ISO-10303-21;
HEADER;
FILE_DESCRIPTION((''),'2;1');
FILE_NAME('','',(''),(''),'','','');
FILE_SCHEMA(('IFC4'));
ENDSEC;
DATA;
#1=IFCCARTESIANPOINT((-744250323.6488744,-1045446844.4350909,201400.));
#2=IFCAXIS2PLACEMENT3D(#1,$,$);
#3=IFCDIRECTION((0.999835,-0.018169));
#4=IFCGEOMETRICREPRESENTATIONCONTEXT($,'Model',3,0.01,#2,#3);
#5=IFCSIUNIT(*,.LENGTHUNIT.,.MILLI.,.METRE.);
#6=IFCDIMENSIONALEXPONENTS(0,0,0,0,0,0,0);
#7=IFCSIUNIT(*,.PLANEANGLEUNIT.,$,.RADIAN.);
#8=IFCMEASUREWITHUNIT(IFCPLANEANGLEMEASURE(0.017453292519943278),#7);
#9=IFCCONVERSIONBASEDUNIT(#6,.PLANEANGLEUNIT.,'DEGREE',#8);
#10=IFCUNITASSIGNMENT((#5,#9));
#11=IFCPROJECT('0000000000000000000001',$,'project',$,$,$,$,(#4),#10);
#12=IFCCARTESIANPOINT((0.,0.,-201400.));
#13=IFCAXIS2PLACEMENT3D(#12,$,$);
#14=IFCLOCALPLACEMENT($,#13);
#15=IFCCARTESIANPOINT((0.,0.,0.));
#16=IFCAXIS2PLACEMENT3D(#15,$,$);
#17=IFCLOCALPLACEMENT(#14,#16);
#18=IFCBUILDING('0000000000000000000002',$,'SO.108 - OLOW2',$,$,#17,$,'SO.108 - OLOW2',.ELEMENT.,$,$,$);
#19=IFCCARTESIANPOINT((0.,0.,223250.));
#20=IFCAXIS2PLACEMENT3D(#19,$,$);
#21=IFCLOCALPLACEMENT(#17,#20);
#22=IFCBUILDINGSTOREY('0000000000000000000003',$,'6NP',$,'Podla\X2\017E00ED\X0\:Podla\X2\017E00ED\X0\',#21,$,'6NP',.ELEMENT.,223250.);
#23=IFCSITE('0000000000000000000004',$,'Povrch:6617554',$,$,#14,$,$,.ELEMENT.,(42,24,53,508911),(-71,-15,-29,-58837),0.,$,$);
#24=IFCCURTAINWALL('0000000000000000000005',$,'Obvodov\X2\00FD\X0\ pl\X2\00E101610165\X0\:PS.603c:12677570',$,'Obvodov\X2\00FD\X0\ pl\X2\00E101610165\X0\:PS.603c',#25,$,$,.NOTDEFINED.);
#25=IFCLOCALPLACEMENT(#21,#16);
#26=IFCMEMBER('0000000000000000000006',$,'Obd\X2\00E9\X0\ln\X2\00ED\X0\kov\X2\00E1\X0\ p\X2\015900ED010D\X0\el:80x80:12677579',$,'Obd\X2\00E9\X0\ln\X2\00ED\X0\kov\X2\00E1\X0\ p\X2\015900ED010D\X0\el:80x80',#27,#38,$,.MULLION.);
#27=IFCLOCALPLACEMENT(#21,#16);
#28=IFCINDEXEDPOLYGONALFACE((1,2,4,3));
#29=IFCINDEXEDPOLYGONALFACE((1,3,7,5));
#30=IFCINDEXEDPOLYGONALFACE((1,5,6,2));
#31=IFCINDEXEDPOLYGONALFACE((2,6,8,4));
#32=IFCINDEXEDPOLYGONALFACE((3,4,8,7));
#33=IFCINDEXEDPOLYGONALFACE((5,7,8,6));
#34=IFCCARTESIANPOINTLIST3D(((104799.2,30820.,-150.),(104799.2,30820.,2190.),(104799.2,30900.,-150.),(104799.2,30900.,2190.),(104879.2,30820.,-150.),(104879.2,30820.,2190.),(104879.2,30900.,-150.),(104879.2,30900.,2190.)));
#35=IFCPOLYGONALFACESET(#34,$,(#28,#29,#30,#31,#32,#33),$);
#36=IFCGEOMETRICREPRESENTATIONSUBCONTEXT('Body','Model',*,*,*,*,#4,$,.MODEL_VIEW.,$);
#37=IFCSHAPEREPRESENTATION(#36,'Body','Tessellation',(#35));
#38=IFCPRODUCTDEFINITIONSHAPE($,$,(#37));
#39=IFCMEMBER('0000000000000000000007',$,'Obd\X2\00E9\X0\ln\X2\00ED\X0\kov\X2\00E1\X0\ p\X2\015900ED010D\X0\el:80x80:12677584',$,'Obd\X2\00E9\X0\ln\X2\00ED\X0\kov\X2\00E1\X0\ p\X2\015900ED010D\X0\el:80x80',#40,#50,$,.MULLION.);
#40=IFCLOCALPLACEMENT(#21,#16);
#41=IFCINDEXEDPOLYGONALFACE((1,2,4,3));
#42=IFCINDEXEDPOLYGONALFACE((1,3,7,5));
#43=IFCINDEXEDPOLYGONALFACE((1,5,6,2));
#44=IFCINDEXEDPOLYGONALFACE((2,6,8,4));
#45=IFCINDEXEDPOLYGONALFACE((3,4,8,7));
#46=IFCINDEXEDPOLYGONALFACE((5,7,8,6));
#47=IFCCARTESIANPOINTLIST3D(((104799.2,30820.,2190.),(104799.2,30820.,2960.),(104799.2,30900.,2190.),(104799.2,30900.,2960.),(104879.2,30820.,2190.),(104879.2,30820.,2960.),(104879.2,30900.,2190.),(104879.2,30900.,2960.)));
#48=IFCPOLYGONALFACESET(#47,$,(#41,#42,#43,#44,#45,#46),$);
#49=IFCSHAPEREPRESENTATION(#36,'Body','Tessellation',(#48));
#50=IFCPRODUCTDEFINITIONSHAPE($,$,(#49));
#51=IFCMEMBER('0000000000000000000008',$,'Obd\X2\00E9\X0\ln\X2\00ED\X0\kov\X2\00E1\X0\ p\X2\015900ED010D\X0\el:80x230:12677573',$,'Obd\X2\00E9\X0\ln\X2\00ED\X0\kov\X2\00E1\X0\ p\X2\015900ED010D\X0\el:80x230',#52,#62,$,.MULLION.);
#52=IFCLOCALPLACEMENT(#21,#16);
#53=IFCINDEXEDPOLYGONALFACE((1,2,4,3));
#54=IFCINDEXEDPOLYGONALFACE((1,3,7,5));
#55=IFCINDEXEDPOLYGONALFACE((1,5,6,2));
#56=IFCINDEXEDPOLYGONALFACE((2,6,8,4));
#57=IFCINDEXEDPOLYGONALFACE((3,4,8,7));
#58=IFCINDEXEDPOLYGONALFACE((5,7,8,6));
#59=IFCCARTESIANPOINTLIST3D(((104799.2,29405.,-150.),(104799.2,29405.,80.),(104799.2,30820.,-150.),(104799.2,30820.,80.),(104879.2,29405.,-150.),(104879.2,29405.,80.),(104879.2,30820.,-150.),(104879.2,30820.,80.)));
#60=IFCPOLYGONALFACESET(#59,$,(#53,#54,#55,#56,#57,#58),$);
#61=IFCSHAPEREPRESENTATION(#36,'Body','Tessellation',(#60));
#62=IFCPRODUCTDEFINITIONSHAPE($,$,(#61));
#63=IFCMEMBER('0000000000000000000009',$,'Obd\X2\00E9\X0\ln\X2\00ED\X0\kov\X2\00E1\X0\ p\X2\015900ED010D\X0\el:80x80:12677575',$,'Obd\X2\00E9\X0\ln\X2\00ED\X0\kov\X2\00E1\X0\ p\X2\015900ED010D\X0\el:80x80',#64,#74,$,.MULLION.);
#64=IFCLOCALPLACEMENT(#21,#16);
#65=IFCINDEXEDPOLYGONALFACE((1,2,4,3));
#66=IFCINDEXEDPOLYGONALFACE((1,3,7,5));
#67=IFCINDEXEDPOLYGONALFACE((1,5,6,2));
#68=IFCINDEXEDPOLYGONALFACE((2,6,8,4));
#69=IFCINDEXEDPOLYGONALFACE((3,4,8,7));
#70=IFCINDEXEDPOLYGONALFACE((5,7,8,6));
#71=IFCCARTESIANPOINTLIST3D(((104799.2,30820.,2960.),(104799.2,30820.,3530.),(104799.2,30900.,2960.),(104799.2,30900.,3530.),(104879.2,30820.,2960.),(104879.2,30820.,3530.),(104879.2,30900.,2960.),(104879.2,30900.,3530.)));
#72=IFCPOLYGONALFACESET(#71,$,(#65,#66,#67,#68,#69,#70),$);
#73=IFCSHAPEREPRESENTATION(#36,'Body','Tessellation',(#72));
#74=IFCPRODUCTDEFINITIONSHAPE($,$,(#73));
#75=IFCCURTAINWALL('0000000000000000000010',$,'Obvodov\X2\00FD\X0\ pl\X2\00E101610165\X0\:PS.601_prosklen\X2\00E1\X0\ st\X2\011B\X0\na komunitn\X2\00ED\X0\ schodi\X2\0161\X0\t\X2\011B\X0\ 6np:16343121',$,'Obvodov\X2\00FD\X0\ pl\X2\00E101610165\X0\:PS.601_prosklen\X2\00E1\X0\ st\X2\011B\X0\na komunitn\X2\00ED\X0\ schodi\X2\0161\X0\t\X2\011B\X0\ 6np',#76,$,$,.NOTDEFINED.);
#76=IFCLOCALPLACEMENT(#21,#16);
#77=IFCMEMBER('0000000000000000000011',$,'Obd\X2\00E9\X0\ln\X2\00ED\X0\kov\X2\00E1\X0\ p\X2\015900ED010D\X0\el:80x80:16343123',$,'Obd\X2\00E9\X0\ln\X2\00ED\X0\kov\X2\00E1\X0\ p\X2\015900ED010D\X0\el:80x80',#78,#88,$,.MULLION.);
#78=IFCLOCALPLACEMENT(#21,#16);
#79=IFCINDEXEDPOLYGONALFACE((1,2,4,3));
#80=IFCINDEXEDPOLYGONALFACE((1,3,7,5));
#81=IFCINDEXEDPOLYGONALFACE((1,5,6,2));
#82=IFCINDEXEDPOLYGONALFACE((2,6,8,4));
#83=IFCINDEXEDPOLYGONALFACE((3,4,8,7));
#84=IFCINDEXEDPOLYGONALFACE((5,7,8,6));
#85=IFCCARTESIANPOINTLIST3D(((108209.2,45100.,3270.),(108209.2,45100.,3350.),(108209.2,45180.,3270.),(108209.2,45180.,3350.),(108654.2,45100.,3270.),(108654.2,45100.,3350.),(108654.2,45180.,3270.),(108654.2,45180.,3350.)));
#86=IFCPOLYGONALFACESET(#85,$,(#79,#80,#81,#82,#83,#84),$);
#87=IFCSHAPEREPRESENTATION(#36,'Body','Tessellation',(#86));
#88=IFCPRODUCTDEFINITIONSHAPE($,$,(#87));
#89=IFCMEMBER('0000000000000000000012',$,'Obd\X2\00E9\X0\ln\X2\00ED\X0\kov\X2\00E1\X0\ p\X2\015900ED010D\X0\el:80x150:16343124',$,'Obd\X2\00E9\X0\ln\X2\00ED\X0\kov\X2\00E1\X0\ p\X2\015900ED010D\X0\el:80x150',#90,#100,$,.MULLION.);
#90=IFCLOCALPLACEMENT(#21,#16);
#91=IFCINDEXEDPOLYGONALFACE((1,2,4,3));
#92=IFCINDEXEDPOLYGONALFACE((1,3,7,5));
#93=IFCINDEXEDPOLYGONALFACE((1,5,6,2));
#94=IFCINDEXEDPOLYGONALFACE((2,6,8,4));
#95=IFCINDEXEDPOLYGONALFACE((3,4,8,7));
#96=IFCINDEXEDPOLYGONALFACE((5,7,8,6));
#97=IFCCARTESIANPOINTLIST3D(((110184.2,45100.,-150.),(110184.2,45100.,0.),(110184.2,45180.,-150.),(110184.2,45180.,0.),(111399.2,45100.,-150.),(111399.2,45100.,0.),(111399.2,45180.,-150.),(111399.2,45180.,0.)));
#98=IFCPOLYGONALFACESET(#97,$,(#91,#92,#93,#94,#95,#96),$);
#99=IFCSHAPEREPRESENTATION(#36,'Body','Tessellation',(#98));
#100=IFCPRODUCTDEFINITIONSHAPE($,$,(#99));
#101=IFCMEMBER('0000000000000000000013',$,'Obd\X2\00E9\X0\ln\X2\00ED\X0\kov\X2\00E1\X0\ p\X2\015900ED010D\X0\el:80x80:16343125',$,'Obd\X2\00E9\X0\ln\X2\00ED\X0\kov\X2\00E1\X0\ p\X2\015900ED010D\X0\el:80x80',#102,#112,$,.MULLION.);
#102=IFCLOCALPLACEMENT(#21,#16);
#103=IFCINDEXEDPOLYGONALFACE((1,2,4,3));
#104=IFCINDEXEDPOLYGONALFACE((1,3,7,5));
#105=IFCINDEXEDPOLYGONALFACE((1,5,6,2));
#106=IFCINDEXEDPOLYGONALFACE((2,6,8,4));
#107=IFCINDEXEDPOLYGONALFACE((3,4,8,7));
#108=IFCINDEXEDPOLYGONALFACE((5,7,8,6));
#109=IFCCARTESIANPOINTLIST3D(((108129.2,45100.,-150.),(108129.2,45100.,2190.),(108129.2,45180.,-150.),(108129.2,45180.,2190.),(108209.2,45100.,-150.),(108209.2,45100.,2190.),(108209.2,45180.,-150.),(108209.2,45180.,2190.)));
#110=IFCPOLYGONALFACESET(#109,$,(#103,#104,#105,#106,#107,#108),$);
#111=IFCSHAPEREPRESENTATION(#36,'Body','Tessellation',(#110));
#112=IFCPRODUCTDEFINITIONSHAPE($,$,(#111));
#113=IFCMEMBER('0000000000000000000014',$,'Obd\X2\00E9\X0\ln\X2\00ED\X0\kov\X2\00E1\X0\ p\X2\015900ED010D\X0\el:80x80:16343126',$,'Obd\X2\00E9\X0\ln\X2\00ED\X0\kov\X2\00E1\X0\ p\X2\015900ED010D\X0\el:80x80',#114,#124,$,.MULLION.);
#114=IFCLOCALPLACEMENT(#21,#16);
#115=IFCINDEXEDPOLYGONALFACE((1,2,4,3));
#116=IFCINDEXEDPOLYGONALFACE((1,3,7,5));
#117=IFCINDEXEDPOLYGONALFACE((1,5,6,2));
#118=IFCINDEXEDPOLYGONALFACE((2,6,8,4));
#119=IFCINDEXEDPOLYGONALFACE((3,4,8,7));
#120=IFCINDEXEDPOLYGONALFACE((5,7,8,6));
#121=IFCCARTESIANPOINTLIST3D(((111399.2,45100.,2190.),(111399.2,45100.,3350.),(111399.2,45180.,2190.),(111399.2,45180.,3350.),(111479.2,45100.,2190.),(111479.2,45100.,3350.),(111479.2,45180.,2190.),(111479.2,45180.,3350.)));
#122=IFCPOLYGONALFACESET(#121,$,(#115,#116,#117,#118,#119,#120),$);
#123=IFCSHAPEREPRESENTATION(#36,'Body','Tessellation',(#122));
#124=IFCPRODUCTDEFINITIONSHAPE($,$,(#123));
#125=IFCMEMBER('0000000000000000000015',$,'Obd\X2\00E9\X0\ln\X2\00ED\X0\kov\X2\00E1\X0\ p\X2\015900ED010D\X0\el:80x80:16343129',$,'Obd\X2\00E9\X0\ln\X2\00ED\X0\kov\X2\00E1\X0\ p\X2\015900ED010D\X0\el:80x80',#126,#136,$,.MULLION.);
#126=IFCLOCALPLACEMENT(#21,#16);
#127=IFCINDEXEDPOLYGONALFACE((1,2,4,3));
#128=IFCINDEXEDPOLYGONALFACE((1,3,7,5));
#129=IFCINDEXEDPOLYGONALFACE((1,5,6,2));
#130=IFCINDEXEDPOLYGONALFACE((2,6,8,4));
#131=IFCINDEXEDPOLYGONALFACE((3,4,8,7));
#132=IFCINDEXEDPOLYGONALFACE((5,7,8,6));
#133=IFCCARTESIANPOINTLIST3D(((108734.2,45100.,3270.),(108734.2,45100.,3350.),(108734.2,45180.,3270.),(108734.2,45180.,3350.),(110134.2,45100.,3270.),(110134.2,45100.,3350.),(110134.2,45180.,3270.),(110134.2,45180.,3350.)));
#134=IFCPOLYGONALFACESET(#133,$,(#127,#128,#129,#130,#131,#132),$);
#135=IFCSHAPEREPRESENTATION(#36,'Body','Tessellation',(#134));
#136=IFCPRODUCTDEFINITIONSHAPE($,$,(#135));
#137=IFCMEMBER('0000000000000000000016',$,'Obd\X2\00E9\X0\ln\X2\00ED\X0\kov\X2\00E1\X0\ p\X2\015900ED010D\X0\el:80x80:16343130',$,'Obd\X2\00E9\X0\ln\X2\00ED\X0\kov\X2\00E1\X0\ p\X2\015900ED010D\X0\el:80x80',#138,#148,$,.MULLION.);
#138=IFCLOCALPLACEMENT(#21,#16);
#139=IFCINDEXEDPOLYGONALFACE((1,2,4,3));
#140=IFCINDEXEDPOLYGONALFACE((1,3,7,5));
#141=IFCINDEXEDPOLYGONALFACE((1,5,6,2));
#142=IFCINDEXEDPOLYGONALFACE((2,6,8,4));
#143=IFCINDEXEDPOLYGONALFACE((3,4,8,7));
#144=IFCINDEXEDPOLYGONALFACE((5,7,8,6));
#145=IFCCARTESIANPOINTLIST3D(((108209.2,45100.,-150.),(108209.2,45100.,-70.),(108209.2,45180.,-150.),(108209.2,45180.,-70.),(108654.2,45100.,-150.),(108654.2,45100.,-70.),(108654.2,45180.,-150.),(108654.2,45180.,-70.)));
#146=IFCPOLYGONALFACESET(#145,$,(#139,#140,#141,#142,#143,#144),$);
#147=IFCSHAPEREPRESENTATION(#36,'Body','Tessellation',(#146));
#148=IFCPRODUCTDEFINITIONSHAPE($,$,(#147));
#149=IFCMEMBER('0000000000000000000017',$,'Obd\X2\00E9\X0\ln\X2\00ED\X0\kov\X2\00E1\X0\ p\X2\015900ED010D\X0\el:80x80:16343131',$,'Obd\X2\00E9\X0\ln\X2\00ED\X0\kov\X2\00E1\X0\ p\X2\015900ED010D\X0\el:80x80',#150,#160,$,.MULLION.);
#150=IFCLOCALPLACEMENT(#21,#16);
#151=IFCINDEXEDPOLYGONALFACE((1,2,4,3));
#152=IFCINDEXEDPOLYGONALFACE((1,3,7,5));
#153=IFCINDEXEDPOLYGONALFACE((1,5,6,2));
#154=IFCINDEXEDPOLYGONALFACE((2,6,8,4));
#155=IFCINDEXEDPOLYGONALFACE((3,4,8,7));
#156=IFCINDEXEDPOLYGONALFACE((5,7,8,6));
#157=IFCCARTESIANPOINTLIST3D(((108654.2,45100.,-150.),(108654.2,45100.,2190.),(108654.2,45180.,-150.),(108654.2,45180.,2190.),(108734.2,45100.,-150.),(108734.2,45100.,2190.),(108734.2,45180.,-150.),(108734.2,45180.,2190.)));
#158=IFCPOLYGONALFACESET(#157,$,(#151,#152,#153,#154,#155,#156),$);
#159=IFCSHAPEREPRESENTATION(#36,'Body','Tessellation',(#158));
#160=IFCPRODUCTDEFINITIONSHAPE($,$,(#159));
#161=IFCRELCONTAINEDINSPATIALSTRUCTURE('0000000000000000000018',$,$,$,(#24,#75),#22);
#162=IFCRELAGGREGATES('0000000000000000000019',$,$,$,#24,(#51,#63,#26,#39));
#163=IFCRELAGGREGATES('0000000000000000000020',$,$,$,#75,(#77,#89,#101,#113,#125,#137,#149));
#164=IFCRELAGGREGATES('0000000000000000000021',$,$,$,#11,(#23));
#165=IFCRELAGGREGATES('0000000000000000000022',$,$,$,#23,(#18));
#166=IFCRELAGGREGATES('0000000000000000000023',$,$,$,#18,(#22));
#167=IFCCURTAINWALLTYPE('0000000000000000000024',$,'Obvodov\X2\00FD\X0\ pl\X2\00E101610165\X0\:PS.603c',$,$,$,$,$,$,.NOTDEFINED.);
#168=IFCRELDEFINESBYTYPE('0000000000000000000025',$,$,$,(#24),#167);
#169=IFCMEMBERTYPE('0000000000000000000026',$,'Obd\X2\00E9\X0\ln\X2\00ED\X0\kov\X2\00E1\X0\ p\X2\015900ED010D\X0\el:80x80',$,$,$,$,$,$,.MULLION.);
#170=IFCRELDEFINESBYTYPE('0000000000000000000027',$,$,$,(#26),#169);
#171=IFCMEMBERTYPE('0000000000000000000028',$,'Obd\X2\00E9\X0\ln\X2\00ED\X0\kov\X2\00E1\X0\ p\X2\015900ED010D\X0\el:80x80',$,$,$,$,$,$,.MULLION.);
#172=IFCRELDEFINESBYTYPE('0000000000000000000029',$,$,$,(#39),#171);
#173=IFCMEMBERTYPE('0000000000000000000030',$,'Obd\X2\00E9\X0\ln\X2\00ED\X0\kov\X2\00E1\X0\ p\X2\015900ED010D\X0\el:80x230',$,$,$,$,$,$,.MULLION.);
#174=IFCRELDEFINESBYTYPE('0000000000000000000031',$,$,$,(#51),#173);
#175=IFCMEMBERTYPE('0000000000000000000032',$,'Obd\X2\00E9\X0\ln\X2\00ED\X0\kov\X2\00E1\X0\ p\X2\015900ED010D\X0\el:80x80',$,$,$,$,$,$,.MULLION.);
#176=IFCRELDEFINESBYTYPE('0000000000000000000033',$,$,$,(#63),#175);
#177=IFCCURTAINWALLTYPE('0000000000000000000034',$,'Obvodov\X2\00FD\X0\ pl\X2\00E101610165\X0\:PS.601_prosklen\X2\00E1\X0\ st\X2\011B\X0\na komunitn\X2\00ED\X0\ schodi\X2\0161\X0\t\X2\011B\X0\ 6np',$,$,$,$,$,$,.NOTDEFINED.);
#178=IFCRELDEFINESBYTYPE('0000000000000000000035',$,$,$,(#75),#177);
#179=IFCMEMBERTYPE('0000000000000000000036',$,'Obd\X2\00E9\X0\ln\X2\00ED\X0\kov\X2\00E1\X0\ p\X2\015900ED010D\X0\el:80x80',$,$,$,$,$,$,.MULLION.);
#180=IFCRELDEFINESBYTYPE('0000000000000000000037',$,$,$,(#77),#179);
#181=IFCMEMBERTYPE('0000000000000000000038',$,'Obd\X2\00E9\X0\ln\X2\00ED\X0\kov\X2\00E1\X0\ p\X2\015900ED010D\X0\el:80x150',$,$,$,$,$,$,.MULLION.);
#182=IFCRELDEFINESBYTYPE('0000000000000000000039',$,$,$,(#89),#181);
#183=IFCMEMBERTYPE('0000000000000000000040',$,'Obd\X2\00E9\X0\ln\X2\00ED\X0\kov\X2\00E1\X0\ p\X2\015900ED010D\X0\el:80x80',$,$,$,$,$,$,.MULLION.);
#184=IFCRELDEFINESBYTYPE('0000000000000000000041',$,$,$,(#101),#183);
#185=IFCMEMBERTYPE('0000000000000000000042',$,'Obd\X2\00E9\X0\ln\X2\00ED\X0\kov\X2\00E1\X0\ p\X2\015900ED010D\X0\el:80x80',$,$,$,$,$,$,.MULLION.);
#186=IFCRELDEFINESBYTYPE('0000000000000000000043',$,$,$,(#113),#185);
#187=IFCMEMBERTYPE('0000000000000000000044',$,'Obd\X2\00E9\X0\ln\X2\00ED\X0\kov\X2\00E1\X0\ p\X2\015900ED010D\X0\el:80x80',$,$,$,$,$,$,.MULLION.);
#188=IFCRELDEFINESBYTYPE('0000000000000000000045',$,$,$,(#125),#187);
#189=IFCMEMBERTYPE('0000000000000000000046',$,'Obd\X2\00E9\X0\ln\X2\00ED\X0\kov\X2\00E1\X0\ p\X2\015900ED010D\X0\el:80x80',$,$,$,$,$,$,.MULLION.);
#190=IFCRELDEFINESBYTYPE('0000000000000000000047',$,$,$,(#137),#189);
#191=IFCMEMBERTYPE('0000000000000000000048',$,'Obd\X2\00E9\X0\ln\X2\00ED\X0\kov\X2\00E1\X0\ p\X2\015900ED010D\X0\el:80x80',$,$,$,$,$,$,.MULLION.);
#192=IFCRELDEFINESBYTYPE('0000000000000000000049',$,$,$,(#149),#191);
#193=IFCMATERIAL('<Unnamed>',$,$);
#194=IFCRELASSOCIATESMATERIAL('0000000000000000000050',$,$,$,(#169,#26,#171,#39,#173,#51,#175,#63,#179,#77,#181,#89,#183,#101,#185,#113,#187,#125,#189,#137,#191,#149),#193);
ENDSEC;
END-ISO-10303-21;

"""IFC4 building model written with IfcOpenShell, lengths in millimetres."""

from ifc_helpers import new_model, entity, si_unit, converted_unit, direction, frame, origin, place, context, subcontext, project, spatial, indexed_curve, outline, extrude, source, transform, mapped, material, type_object, type_shapes, element, aggregate, save


model = new_model("IFC4")

# Units and contexts
model_context = context("Model", 3, precision=0.01, world=frame((-744250323.6488744, -1045446844.4350909, 201400.0)), true_north=direction((0.999835, -0.018169)))
body_context = subcontext(model_context, "Body", "Model", "MODEL_VIEW")
ifc_project = project(units=[si_unit("LENGTHUNIT", "METRE", prefix="MILLI"), converted_unit("PLANEANGLEUNIT", "DEGREE", entity("IfcPlaneAngleMeasure", 0.017453292519943278), si_unit("PLANEANGLEUNIT", "RADIAN"), dimensions=[0, 0, 0, 0, 0, 0, 0])], contexts=[model_context])

# Site, building, storey
site_placement = place(None, frame((0.0, 0.0, -201400.0)))
site = spatial("IfcSite", under=ifc_project, at=site_placement, Name="Povrch:6617554", CompositionType="ELEMENT", RefLatitude=(42, 24, 53, 508911), RefLongitude=(-71, -15, -29, -58837), RefElevation=0.0)
building_placement = place(site_placement, origin())
building = spatial("IfcBuilding", under=site, at=building_placement, Name="SO.108 - OLOW2", LongName="SO.108 - OLOW2", CompositionType="ELEMENT")
storey_placement = place(building_placement, frame((0.0, 0.0, 223250.0)))
storey = spatial("IfcBuildingStorey", under=building, at=storey_placement, Name="6NP", ObjectType="Podlaží:Podlaží", LongName="6NP", CompositionType="ELEMENT", Elevation=223250.0)

# Curtain wall, members
curtain_wall_type_1 = type_object("IfcCurtainWallType", Name="Obvodový plášť:PS.603c", PredefinedType="NOTDEFINED")
curtain_wall_1_placement = place(storey_placement, frame((0.0, 0.0, -223250.0)))
curtain_wall_1 = element("IfcCurtainWall", 1, at=curtain_wall_1_placement, inside=storey, type_object=curtain_wall_type_1, Name="Obvodový plášť:PS.603c:12677570", ObjectType="Obvodový plášť:PS.603c", PredefinedType="NOTDEFINED")
ifc_material_1 = material(Name="<Unnamed>")
member_type_1 = type_object("IfcMemberType", Name="Obdélníková příčel:80x80", PredefinedType="MULLION", material=ifc_material_1)
shared_shape_1 = source(origin(), body_context, "Body", "SweptSolid", [
    extrude(outline(indexed_curve([(-40.0, -40.0), (40.0, -40.0), (40.0, 40.0), (-40.0, 40.0), (-40.0, -40.0)], self_intersect=False)), frame((-40.0, 0.0, -2340.0), z_axis=(0.0, 0.0, 1.0), x_axis=(-1.0, 0.0, 0.0)), (0.0, 0.0, 1.0), 2340.0),
])
type_shapes(member_type_1, [shared_shape_1])
member_1_placement = place(curtain_wall_1_placement, frame((104839.2, 30900.0, 225440.0), z_axis=(0.0, 0.0, 1.0), x_axis=(0.0, 1.0, 0.0)))
member_1 = element("IfcMember", 2, at=member_1_placement, type_object=member_type_1, material=ifc_material_1, Name="Obdélníková příčel:80x80:12677579", ObjectType="Obdélníková příčel:80x80", PredefinedType="MULLION", context=body_context, shape_type="MappedRepresentation", body=[
    mapped(shared_shape_1, transform((0.0, 0.0, 0.0), scale=1.0)),
])
member_type_2 = type_object("IfcMemberType", Name="Obdélníková příčel:80x80", PredefinedType="MULLION", material=ifc_material_1)
shared_shape_2 = source(origin(), body_context, "Body", "SweptSolid", [
    extrude(outline(indexed_curve([(-40.0, -40.0), (40.0, -40.0), (40.0, 40.0), (-40.0, 40.0), (-40.0, -40.0)], self_intersect=False)), frame((-40.0, 0.0, -770.0), z_axis=(0.0, 0.0, 1.0), x_axis=(-1.0, 0.0, 0.0)), (0.0, 0.0, 1.0), 770.0),
])
type_shapes(member_type_2, [shared_shape_2])
member_2_placement = place(curtain_wall_1_placement, frame((104839.2, 30900.0, 226210.0), z_axis=(0.0, 0.0, 1.0), x_axis=(0.0, 1.0, 0.0)))
member_2 = element("IfcMember", 3, at=member_2_placement, type_object=member_type_2, material=ifc_material_1, Name="Obdélníková příčel:80x80:12677584", ObjectType="Obdélníková příčel:80x80", PredefinedType="MULLION", context=body_context, shape_type="MappedRepresentation", body=[
    mapped(shared_shape_2, transform((0.0, 0.0, 0.0), scale=1.0)),
])
member_type_3 = type_object("IfcMemberType", Name="Obdélníková příčel:80x230", PredefinedType="MULLION", material=ifc_material_1)
shared_shape_3 = source(origin(), body_context, "Body", "SweptSolid", [
    extrude(outline(indexed_curve([(-115.0, -40.0), (115.0, -40.0), (115.0, 40.0), (-115.0, 40.0), (-115.0, -40.0)], self_intersect=False)), frame((-115.0, 0.0, -1415.0), z_axis=(0.0, 0.0, 1.0), x_axis=(-1.0, 0.0, 0.0)), (0.0, 0.0, 1.0), 1415.0),
])
type_shapes(member_type_3, [shared_shape_3])
member_3_placement = place(curtain_wall_1_placement, frame((104839.2, 30820.0, 223100.0), z_axis=(0.0, 1.0, 0.0), x_axis=(0.0, 0.0, -1.0)))
member_3 = element("IfcMember", 4, at=member_3_placement, type_object=member_type_3, material=ifc_material_1, Name="Obdélníková příčel:80x230:12677573", ObjectType="Obdélníková příčel:80x230", PredefinedType="MULLION", context=body_context, shape_type="MappedRepresentation", body=[
    mapped(shared_shape_3, transform((0.0, 0.0, 0.0), scale=1.0)),
])
member_type_4 = type_object("IfcMemberType", Name="Obdélníková příčel:80x80", PredefinedType="MULLION", material=ifc_material_1)
shared_shape_4 = source(origin(), body_context, "Body", "SweptSolid", [
    extrude(outline(indexed_curve([(-40.0, -40.0), (40.0, -40.0), (40.0, 40.0), (-40.0, 40.0), (-40.0, -40.0)], self_intersect=False)), frame((-40.0, 0.0, -570.0), z_axis=(0.0, 0.0, 1.0), x_axis=(-1.0, 0.0, 0.0)), (0.0, 0.0, 1.0), 570.0),
])
type_shapes(member_type_4, [shared_shape_4])
member_4_placement = place(curtain_wall_1_placement, frame((104839.2, 30900.0, 226780.0), z_axis=(0.0, 0.0, 1.0), x_axis=(0.0, 1.0, 0.0)))
member_4 = element("IfcMember", 5, at=member_4_placement, type_object=member_type_4, material=ifc_material_1, Name="Obdélníková příčel:80x80:12677575", ObjectType="Obdélníková příčel:80x80", PredefinedType="MULLION", context=body_context, shape_type="MappedRepresentation", body=[
    mapped(shared_shape_4, transform((0.0, 0.0, 0.0), scale=1.0)),
])
aggregate(curtain_wall_1, [member_3, member_4, member_1, member_2])

# Curtain wall, members
curtain_wall_type_2 = type_object("IfcCurtainWallType", Name="Obvodový plášť:PS.601_prosklená stěna komunitní schodiště 6np", PredefinedType="NOTDEFINED")
curtain_wall_2_placement = place(storey_placement, frame((0.0, 0.0, -223250.0)))
curtain_wall_2 = element("IfcCurtainWall", 6, at=curtain_wall_2_placement, inside=storey, type_object=curtain_wall_type_2, Name="Obvodový plášť:PS.601_prosklená stěna komunitní schodiště 6np:16343121", ObjectType="Obvodový plášť:PS.601_prosklená stěna komunitní schodiště 6np", PredefinedType="NOTDEFINED")
member_type_5 = type_object("IfcMemberType", Name="Obdélníková příčel:80x80", PredefinedType="MULLION", material=ifc_material_1)
shared_shape_5 = source(origin(), body_context, "Body", "SweptSolid", [
    extrude(outline(indexed_curve([(-40.0, -40.0), (40.0, -40.0), (40.0, 40.0), (-40.0, 40.0), (-40.0, -40.0)], self_intersect=False)), frame((-40.0, 0.0, -445.0), z_axis=(0.0, 0.0, 1.0), x_axis=(-1.0, 0.0, 0.0)), (0.0, 0.0, 1.0), 445.0),
])
type_shapes(member_type_5, [shared_shape_5])
member_5_placement = place(curtain_wall_2_placement, frame((108209.2, 45140.0, 226600.0), z_axis=(-1.0, 0.0, 0.0), x_axis=(0.0, 0.0, 1.0)))
member_5 = element("IfcMember", 7, at=member_5_placement, type_object=member_type_5, material=ifc_material_1, Name="Obdélníková příčel:80x80:16343123", ObjectType="Obdélníková příčel:80x80", PredefinedType="MULLION", context=body_context, shape_type="MappedRepresentation", body=[
    mapped(shared_shape_5, transform((0.0, 0.0, 0.0), scale=1.0)),
])
member_type_6 = type_object("IfcMemberType", Name="Obdélníková příčel:80x150", PredefinedType="MULLION", material=ifc_material_1)
shared_shape_6 = source(origin(), body_context, "Body", "SweptSolid", [
    extrude(outline(indexed_curve([(-75.0, -40.0), (75.0, -40.0), (75.0, 40.0), (-75.0, 40.0), (-75.0, -40.0)], self_intersect=False)), frame((-75.0, 0.0, -1215.0), z_axis=(0.0, 0.0, 1.0), x_axis=(-1.0, 0.0, 0.0)), (0.0, 0.0, 1.0), 1215.0),
])
type_shapes(member_type_6, [shared_shape_6])
member_6_placement = place(curtain_wall_2_placement, frame((111399.2, 45140.0, 223100.0), z_axis=(1.0, 0.0, 0.0), x_axis=(0.0, 0.0, -1.0)))
member_6 = element("IfcMember", 8, at=member_6_placement, type_object=member_type_6, material=ifc_material_1, Name="Obdélníková příčel:80x150:16343124", ObjectType="Obdélníková příčel:80x150", PredefinedType="MULLION", context=body_context, shape_type="MappedRepresentation", body=[
    mapped(shared_shape_6, transform((0.0, 0.0, 0.0), scale=1.0)),
])
member_type_7 = type_object("IfcMemberType", Name="Obdélníková příčel:80x80", PredefinedType="MULLION", material=ifc_material_1)
shared_shape_7 = source(origin(), body_context, "Body", "SweptSolid", [
    extrude(outline(indexed_curve([(-40.0, -40.0), (40.0, -40.0), (40.0, 40.0), (-40.0, 40.0), (-40.0, -40.0)], self_intersect=False)), frame((-40.0, 0.0, -2340.0), z_axis=(0.0, 0.0, 1.0), x_axis=(-1.0, 0.0, 0.0)), (0.0, 0.0, 1.0), 2340.0),
])
type_shapes(member_type_7, [shared_shape_7])
member_7_placement = place(curtain_wall_2_placement, frame((108129.2, 45140.0, 223100.0), z_axis=(0.0, 0.0, -1.0), x_axis=(-1.0, 0.0, 0.0)))
member_7 = element("IfcMember", 9, at=member_7_placement, type_object=member_type_7, material=ifc_material_1, Name="Obdélníková příčel:80x80:16343125", ObjectType="Obdélníková příčel:80x80", PredefinedType="MULLION", context=body_context, shape_type="MappedRepresentation", body=[
    mapped(shared_shape_7, transform((0.0, 0.0, 0.0), scale=1.0)),
])
member_type_8 = type_object("IfcMemberType", Name="Obdélníková příčel:80x80", PredefinedType="MULLION", material=ifc_material_1)
shared_shape_8 = source(origin(), body_context, "Body", "SweptSolid", [
    extrude(outline(indexed_curve([(-40.0, -40.0), (40.0, -40.0), (40.0, 40.0), (-40.0, 40.0), (-40.0, -40.0)], self_intersect=False)), frame((-40.0, 0.0, -1160.0), z_axis=(0.0, 0.0, 1.0), x_axis=(-1.0, 0.0, 0.0)), (0.0, 0.0, 1.0), 1160.0),
])
type_shapes(member_type_8, [shared_shape_8])
member_8_placement = place(curtain_wall_2_placement, frame((111479.2, 45140.0, 226600.0)))
member_8 = element("IfcMember", 10, at=member_8_placement, type_object=member_type_8, material=ifc_material_1, Name="Obdélníková příčel:80x80:16343126", ObjectType="Obdélníková příčel:80x80", PredefinedType="MULLION", context=body_context, shape_type="MappedRepresentation", body=[
    mapped(shared_shape_8, transform((0.0, 0.0, 0.0), scale=1.0)),
])
member_type_9 = type_object("IfcMemberType", Name="Obdélníková příčel:80x80", PredefinedType="MULLION", material=ifc_material_1)
shared_shape_9 = source(origin(), body_context, "Body", "SweptSolid", [
    extrude(outline(indexed_curve([(-40.0, -40.0), (40.0, -40.0), (40.0, 40.0), (-40.0, 40.0), (-40.0, -40.0)], self_intersect=False)), frame((-40.0, 0.0, -1400.0), z_axis=(0.0, 0.0, 1.0), x_axis=(-1.0, 0.0, 0.0)), (0.0, 0.0, 1.0), 1400.0),
])
type_shapes(member_type_9, [shared_shape_9])
member_9_placement = place(curtain_wall_2_placement, frame((108734.2, 45140.0, 226600.0), z_axis=(-1.0, 0.0, 0.0), x_axis=(0.0, 0.0, 1.0)))
member_9 = element("IfcMember", 11, at=member_9_placement, type_object=member_type_9, material=ifc_material_1, Name="Obdélníková příčel:80x80:16343129", ObjectType="Obdélníková příčel:80x80", PredefinedType="MULLION", context=body_context, shape_type="MappedRepresentation", body=[
    mapped(shared_shape_9, transform((0.0, 0.0, 0.0), scale=1.0)),
])
member_type_10 = type_object("IfcMemberType", Name="Obdélníková příčel:80x80", PredefinedType="MULLION", material=ifc_material_1)
shared_shape_10 = source(origin(), body_context, "Body", "SweptSolid", [
    extrude(outline(indexed_curve([(-40.0, -40.0), (40.0, -40.0), (40.0, 40.0), (-40.0, 40.0), (-40.0, -40.0)], self_intersect=False)), frame((-40.0, 0.0, -445.0), z_axis=(0.0, 0.0, 1.0), x_axis=(-1.0, 0.0, 0.0)), (0.0, 0.0, 1.0), 445.0),
])
type_shapes(member_type_10, [shared_shape_10])
member_10_placement = place(curtain_wall_2_placement, frame((108654.2, 45140.0, 223100.0), z_axis=(1.0, 0.0, 0.0), x_axis=(0.0, 0.0, -1.0)))
member_10 = element("IfcMember", 12, at=member_10_placement, type_object=member_type_10, material=ifc_material_1, Name="Obdélníková příčel:80x80:16343130", ObjectType="Obdélníková příčel:80x80", PredefinedType="MULLION", context=body_context, shape_type="MappedRepresentation", body=[
    mapped(shared_shape_10, transform((0.0, 0.0, 0.0), scale=1.0)),
])
member_type_11 = type_object("IfcMemberType", Name="Obdélníková příčel:80x80", PredefinedType="MULLION", material=ifc_material_1)
shared_shape_11 = source(origin(), body_context, "Body", "SweptSolid", [
    extrude(outline(indexed_curve([(-40.0, -40.0), (40.0, -40.0), (40.0, 40.0), (-40.0, 40.0), (-40.0, -40.0)], self_intersect=False)), frame((0.0, 0.0, -2340.0), z_axis=(0.0, 0.0, 1.0), x_axis=(-1.0, 0.0, 0.0)), (0.0, 0.0, 1.0), 2340.0),
])
type_shapes(member_type_11, [shared_shape_11])
member_11_placement = place(curtain_wall_2_placement, frame((108694.2, 45140.0, 223100.0), z_axis=(0.0, 0.0, -1.0), x_axis=(-1.0, 0.0, 0.0)))
member_11 = element("IfcMember", 13, at=member_11_placement, type_object=member_type_11, material=ifc_material_1, Name="Obdélníková příčel:80x80:16343131", ObjectType="Obdélníková příčel:80x80", PredefinedType="MULLION", context=body_context, shape_type="MappedRepresentation", body=[
    mapped(shared_shape_11, transform((0.0, 0.0, 0.0), scale=1.0)),
])
aggregate(curtain_wall_2, [member_5, member_6, member_7, member_8, member_9, member_10, member_11])

save(model, "model.ifc")
